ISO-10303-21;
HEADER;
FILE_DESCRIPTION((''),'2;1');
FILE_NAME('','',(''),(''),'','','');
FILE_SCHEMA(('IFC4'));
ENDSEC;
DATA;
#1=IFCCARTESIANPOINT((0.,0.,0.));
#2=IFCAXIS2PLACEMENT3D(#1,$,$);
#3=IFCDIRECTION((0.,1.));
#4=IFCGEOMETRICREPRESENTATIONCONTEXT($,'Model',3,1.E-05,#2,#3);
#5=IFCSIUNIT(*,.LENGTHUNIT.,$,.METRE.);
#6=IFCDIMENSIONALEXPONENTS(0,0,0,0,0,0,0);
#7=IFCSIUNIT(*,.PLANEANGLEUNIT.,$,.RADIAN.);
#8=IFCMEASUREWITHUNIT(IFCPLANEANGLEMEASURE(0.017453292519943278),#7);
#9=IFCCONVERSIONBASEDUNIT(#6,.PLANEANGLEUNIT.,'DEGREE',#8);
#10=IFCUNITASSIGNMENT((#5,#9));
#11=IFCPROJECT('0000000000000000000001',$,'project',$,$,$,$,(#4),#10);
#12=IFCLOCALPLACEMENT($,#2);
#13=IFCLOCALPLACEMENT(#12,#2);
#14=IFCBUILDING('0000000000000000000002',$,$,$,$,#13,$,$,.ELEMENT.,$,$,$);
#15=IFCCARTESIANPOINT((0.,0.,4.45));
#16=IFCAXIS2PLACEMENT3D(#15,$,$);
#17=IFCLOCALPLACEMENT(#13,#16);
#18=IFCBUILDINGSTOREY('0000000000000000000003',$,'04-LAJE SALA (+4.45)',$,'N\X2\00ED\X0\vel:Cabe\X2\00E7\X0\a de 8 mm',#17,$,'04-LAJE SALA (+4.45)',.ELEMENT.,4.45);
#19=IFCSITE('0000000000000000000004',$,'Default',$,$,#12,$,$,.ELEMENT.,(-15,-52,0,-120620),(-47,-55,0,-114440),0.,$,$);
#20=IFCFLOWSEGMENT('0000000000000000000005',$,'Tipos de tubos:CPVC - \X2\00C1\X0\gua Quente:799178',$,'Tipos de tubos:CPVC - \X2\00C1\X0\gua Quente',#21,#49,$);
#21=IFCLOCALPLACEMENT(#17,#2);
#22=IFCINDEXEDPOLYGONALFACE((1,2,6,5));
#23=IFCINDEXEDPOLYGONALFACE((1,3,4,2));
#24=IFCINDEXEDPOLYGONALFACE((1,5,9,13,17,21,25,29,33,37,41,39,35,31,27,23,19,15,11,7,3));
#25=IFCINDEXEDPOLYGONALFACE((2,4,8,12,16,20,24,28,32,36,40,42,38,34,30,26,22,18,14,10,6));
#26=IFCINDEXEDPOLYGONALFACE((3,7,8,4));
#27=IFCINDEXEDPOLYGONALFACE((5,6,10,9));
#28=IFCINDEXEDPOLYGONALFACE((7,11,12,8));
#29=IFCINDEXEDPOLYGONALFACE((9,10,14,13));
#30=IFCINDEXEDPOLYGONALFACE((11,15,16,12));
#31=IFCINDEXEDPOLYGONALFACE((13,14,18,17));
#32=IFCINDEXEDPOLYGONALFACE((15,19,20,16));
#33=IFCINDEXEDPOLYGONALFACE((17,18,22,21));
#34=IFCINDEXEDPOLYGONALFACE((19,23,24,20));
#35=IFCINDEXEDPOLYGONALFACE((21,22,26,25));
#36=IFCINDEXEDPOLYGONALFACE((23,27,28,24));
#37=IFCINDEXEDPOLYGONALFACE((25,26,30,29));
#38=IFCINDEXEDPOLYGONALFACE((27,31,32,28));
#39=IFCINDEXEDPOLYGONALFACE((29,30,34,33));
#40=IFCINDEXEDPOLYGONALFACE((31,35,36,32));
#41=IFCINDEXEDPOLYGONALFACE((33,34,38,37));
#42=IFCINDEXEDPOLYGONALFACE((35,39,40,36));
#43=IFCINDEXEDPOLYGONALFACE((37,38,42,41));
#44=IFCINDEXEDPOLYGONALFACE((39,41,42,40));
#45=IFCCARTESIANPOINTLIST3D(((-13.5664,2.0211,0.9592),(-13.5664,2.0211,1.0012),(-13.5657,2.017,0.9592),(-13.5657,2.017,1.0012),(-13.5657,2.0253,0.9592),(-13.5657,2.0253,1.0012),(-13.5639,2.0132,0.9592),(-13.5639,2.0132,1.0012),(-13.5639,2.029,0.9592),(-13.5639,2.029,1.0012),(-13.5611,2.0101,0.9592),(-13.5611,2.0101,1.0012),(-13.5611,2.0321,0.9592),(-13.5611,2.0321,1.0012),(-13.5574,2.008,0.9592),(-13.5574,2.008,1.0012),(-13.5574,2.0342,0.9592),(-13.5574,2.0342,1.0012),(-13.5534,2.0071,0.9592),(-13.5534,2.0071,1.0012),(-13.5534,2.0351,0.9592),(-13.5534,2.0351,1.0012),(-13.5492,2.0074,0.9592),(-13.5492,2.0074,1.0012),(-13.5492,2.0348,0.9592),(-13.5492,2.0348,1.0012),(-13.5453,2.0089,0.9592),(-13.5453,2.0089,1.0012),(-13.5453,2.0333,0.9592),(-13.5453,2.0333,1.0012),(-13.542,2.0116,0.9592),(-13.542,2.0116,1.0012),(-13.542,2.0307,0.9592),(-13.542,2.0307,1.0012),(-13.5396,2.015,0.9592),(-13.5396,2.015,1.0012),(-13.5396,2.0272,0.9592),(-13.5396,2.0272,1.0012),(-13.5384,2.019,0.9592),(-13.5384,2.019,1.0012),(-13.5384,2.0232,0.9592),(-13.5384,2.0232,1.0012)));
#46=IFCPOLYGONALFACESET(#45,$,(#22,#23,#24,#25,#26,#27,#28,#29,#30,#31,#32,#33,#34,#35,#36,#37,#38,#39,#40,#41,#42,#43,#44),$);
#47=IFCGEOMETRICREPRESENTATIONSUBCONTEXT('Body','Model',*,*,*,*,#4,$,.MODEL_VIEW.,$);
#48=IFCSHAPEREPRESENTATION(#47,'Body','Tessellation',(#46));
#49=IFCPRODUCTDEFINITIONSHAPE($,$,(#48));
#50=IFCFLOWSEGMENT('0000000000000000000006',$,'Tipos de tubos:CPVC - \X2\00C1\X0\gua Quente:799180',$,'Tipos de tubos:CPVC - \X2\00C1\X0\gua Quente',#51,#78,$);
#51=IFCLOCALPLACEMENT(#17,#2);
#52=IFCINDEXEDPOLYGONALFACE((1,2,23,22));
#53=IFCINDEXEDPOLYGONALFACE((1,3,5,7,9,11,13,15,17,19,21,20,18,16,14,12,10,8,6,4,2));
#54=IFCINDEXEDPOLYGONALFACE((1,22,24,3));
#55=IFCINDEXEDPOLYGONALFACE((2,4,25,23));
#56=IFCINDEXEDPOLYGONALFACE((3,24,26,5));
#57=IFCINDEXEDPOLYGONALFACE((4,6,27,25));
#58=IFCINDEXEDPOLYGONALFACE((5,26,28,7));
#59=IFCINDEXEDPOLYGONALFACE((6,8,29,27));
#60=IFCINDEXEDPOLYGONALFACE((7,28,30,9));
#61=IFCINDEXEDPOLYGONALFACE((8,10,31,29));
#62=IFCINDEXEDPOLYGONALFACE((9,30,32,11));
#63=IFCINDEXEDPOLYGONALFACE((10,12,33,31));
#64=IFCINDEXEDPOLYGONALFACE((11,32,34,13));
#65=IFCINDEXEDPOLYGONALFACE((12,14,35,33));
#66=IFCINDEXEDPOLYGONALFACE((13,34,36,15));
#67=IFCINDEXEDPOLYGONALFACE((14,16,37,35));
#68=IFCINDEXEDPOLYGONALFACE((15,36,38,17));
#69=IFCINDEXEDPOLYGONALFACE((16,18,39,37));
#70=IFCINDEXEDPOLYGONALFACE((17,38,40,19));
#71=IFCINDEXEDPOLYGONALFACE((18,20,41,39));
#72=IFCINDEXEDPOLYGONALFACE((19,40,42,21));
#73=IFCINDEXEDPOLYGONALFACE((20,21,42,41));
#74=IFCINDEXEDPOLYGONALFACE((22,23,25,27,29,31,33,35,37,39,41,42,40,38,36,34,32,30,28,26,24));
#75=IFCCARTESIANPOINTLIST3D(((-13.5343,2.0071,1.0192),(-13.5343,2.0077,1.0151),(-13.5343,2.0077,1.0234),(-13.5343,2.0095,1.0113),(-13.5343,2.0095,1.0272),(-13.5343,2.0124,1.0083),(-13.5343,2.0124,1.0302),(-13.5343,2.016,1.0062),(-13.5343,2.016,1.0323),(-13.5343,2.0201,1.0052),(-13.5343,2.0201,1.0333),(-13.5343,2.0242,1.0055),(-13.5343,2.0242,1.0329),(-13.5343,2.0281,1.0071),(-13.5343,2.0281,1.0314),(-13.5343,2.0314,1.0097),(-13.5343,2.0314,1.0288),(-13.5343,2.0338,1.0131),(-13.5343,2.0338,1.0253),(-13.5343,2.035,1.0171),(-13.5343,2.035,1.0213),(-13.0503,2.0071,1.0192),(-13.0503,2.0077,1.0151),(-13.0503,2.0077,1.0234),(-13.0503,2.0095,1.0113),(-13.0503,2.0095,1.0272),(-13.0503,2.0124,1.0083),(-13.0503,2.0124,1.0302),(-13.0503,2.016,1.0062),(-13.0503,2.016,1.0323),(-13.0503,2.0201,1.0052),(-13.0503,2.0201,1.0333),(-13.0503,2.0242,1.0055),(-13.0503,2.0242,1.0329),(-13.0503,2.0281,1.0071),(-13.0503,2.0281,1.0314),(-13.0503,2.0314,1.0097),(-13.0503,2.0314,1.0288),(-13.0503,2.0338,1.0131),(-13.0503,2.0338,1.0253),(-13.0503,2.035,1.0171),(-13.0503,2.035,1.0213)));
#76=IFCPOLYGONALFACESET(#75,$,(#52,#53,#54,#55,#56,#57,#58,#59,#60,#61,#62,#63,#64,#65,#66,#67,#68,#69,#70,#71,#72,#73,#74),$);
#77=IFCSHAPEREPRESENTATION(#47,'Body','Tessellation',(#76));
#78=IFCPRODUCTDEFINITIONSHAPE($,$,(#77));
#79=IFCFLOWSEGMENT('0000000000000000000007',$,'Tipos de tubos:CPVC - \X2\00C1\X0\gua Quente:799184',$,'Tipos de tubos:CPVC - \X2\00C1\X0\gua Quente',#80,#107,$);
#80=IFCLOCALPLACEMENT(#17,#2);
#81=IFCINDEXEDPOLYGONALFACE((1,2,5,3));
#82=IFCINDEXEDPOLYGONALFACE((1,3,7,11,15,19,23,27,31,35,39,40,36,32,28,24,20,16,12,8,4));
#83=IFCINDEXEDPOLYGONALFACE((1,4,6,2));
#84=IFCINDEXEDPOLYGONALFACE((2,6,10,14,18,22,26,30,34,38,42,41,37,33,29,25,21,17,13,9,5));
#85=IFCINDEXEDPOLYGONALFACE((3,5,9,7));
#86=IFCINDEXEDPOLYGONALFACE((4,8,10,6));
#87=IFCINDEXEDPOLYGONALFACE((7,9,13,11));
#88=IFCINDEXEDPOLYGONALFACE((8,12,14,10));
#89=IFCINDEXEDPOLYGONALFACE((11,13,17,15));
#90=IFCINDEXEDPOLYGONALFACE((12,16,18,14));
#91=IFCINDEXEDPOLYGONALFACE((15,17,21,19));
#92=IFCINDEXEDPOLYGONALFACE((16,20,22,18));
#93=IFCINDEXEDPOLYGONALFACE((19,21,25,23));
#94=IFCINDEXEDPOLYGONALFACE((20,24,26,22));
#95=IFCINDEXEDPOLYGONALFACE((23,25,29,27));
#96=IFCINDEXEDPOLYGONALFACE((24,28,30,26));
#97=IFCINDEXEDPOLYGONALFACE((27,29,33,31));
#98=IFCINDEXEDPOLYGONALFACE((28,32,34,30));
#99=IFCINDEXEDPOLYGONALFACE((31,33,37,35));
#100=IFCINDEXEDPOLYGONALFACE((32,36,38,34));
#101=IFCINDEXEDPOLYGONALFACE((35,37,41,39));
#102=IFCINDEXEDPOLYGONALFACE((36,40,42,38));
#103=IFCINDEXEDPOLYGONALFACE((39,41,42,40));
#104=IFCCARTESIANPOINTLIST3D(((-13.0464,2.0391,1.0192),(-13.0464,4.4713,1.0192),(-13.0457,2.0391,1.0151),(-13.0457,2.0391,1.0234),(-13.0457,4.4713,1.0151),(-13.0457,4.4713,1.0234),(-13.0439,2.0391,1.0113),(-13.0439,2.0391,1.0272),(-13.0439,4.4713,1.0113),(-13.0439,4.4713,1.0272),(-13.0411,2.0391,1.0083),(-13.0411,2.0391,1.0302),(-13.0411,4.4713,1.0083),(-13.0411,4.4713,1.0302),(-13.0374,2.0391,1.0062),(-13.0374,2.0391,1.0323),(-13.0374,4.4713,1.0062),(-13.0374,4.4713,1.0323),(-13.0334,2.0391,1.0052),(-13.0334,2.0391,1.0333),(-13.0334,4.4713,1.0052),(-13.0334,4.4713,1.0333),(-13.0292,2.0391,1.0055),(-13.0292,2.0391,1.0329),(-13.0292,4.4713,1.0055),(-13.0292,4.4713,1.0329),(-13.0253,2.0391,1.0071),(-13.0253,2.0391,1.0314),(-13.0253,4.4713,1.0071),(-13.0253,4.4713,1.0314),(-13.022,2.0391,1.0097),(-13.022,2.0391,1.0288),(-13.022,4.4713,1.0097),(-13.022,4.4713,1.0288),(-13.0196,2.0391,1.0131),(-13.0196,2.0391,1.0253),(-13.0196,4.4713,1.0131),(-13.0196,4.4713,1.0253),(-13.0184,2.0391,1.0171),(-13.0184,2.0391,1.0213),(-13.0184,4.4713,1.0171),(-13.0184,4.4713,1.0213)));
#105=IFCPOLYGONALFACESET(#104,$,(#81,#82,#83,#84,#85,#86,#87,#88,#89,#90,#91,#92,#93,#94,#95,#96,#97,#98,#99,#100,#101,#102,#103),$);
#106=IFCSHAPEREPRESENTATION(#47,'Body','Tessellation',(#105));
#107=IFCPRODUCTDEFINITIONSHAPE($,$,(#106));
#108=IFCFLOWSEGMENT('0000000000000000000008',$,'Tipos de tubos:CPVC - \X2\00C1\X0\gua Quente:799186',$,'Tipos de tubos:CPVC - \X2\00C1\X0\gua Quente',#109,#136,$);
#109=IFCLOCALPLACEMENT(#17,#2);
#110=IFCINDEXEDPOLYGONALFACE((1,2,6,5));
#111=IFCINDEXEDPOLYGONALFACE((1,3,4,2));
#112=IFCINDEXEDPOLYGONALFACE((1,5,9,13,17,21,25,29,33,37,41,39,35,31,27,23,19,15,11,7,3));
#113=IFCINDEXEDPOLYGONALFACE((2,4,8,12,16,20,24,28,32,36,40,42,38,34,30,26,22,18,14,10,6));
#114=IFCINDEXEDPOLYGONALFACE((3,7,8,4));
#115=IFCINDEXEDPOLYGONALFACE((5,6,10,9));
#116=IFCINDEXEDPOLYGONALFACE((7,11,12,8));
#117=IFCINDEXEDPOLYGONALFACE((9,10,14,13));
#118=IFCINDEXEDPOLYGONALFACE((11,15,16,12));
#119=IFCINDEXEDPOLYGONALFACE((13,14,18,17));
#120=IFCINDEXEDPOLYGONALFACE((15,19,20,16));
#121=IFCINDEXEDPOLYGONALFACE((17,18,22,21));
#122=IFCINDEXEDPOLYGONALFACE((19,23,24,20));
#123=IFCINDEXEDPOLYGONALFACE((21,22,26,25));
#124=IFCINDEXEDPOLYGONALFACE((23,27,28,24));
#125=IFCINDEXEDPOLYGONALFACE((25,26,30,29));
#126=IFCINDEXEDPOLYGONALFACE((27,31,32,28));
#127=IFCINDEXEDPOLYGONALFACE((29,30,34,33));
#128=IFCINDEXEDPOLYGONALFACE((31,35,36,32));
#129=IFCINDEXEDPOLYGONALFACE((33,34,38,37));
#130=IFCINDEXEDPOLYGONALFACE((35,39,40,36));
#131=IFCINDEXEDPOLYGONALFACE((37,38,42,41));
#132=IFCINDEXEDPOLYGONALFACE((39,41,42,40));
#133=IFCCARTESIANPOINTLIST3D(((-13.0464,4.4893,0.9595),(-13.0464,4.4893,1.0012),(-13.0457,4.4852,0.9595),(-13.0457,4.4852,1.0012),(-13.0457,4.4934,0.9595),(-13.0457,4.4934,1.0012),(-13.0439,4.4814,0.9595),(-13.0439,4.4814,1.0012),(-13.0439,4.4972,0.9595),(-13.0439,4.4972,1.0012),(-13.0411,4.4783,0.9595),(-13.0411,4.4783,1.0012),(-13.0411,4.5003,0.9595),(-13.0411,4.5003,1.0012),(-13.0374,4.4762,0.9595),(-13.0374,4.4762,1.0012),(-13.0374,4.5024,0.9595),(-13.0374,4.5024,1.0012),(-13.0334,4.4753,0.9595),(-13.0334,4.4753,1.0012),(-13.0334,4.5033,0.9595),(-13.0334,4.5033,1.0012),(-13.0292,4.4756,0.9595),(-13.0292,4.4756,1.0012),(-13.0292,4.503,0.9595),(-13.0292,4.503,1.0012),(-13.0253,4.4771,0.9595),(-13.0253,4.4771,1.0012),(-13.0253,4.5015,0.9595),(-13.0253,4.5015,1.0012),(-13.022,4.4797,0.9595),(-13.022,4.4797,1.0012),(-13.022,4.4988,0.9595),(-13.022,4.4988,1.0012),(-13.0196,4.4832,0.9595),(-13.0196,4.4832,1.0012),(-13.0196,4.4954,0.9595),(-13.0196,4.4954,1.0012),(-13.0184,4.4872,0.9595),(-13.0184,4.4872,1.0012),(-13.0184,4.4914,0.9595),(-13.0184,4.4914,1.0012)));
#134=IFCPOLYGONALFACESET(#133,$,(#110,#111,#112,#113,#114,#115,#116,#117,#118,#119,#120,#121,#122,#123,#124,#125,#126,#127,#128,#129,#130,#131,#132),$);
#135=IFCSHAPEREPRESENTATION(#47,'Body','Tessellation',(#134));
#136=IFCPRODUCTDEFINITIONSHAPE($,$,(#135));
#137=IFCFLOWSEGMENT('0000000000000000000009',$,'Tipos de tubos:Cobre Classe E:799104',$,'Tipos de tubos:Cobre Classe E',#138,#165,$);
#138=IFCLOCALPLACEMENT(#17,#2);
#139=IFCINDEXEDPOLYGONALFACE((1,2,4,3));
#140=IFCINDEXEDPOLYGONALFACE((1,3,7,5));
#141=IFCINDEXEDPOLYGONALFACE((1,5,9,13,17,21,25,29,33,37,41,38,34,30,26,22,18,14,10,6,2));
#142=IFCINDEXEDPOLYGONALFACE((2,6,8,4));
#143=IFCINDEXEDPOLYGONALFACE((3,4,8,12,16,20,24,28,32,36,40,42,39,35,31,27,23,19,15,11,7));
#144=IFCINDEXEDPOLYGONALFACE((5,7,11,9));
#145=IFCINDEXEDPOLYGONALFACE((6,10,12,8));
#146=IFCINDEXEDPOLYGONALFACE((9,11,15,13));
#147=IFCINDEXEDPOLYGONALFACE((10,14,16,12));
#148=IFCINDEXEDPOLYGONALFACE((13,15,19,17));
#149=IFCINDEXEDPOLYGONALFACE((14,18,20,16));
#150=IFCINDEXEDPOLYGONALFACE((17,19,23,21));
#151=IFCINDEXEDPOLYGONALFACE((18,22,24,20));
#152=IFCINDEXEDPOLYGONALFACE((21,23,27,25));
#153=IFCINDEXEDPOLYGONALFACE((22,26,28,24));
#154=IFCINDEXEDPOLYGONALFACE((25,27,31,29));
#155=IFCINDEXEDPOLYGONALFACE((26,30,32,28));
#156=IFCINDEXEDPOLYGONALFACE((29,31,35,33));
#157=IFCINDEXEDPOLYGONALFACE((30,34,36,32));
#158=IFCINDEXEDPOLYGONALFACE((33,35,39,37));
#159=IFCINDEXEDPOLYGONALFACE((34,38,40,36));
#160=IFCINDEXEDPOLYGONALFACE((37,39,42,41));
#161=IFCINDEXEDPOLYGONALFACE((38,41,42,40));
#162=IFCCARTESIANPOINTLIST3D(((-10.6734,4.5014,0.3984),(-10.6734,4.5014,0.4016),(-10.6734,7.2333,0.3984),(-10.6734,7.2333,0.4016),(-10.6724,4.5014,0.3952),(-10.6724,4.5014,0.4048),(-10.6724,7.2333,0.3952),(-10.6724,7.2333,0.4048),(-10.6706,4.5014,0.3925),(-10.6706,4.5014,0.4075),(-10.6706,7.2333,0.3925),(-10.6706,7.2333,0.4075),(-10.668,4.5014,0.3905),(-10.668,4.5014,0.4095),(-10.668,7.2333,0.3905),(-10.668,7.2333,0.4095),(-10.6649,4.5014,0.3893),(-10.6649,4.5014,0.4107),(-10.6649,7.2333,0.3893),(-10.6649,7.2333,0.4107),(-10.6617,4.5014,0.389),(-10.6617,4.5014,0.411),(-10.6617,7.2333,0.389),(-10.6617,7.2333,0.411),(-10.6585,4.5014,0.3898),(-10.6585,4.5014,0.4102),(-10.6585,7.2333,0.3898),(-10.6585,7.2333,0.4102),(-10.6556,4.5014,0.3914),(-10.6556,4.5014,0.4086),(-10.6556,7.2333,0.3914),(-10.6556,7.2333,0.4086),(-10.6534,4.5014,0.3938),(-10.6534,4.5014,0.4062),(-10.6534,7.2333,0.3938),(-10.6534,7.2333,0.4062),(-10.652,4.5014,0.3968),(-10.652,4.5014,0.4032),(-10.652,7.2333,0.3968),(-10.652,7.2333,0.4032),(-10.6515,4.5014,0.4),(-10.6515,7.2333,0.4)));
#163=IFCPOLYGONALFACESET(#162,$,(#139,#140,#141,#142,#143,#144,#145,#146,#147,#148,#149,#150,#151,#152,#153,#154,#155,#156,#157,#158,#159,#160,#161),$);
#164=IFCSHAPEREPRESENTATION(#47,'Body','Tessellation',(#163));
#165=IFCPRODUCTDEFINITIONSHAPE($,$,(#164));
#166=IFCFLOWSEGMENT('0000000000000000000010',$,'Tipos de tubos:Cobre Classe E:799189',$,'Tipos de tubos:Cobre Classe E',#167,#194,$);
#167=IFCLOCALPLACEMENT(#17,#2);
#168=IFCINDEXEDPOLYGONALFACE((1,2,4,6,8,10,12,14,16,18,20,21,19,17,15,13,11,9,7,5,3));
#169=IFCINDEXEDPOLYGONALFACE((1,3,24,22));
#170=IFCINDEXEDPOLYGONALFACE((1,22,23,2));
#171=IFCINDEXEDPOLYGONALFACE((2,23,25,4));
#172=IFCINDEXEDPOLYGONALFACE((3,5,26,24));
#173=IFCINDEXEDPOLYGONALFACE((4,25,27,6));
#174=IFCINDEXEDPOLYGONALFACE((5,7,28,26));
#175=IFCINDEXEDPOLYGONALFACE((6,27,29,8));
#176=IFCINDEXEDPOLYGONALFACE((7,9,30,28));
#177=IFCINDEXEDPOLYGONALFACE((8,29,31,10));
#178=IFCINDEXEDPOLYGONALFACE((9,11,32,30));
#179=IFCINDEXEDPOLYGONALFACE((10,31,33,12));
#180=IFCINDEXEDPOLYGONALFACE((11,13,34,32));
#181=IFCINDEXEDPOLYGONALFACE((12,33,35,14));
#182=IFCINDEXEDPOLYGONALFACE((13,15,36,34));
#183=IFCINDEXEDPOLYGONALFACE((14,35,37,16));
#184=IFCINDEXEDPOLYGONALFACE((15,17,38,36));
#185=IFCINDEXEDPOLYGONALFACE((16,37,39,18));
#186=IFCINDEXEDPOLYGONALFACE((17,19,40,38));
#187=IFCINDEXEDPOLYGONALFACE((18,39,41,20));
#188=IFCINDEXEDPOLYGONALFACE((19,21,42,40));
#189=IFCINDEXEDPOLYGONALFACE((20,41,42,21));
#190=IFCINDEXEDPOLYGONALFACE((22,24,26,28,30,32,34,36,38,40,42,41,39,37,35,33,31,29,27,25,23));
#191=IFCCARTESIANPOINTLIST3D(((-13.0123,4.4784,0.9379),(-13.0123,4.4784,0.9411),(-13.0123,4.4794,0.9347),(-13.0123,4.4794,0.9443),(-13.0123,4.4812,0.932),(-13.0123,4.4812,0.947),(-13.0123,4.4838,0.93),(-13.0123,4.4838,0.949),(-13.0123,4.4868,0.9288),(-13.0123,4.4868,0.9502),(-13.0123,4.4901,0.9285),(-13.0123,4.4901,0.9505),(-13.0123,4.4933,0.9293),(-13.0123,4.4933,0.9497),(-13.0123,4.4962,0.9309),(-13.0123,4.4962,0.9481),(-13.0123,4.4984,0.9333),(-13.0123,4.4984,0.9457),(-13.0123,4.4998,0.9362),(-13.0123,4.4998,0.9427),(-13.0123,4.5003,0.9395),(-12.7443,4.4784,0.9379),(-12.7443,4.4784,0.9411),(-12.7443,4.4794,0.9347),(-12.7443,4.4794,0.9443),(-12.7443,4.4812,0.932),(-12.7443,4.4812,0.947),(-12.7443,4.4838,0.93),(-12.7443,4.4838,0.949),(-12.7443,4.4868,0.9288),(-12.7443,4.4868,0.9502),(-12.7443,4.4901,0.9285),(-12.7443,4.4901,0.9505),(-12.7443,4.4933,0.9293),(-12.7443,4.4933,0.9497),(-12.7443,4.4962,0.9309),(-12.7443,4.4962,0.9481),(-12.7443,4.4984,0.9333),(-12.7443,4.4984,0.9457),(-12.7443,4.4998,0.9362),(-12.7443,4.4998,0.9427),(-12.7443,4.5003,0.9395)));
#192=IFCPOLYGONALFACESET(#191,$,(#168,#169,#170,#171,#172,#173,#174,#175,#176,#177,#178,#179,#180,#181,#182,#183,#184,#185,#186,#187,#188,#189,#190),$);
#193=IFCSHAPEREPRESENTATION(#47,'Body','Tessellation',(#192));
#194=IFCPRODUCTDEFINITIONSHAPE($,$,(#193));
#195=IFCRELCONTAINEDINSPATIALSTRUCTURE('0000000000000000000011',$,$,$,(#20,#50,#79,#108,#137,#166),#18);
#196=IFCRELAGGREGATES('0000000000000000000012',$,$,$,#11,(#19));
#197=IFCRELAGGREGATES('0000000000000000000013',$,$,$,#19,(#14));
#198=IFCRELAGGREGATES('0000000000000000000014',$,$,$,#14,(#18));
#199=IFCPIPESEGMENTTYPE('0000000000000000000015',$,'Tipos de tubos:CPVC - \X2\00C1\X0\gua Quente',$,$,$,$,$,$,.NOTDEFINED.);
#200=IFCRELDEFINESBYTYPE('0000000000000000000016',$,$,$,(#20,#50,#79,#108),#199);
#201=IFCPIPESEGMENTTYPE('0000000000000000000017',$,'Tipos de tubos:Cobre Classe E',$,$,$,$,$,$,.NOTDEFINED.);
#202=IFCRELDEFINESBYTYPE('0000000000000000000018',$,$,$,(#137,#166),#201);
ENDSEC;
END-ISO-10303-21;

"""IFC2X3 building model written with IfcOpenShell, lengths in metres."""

from ifc_helpers import new_model, entity, si_unit, converted_unit, direction, frame, frame_2d, origin, origin_2d_with_axis, place, context, subcontext, project, spatial, circle, extrude, type_object, element, save


model = new_model("IFC2X3")

# Units and contexts
model_context = context("Model", 3, precision=1e-05, world=origin(), true_north=direction((0.0, 1.0)))
body_context = subcontext(model_context, "Body", "Model", "MODEL_VIEW")
ifc_project = project(units=[si_unit("LENGTHUNIT", "METRE"), converted_unit("PLANEANGLEUNIT", "DEGREE", entity("IfcPlaneAngleMeasure", 0.017453292519943278), si_unit("PLANEANGLEUNIT", "RADIAN"), dimensions=[0, 0, 0, 0, 0, 0, 0])], contexts=[model_context])

# Site, building, storey
site_placement = place(None, origin())
site = spatial("IfcSite", under=ifc_project, at=site_placement, Name="Default", CompositionType="ELEMENT", RefLatitude=(-15, -52, 0, -120620), RefLongitude=(-47, -55, 0, -114440), RefElevation=0.0)
building_placement = place(site_placement, origin())
building = spatial("IfcBuilding", under=site, at=building_placement, CompositionType="ELEMENT")
storey_placement = place(building_placement, frame((0.0, 0.0, 4.45)))
storey = spatial("IfcBuildingStorey", under=building, at=storey_placement, Name="04-LAJE SALA (+4.45)", ObjectType="Nível:Cabeça de 8 mm", LongName="04-LAJE SALA (+4.45)", CompositionType="ELEMENT", Elevation=4.45)

# Flow segments
pipe_segment_type_1 = type_object("IfcPipeSegmentType", Name="Tipos de tubos:CPVC - Água Quente", PredefinedType="NOTDEFINED")
flow_segment_1_placement = place(storey_placement, origin())
element("IfcFlowSegment", 1, at=flow_segment_1_placement, inside=storey, type_object=pipe_segment_type_1, Name="Tipos de tubos:CPVC - Água Quente:799178", ObjectType="Tipos de tubos:CPVC - Água Quente", context=body_context, shape_type="SweptSolid", body=[
    extrude(circle(Radius=0.0141, at=origin_2d_with_axis()), frame((-13.5523, 2.0211, 0.9592), z_axis=(0.0, 0.0, 1.0), x_axis=(-1.0, 0.0, 0.0)), (0.0, 0.0, 1.0), 0.042),
])
flow_segment_2_placement = place(storey_placement, origin())
element("IfcFlowSegment", 2, at=flow_segment_2_placement, inside=storey, type_object=pipe_segment_type_1, Name="Tipos de tubos:CPVC - Água Quente:799180", ObjectType="Tipos de tubos:CPVC - Água Quente", context=body_context, shape_type="SweptSolid", body=[
    extrude(circle(Radius=0.0141, at=origin_2d_with_axis()), frame((-13.5343, 2.0211, 1.0192), z_axis=(1.0, 0.0, 0.0), x_axis=(0.0, -1.0, 0.0)), (0.0, 0.0, 1.0), 0.484),
])
flow_segment_3_placement = place(storey_placement, origin())
element("IfcFlowSegment", 3, at=flow_segment_3_placement, inside=storey, type_object=pipe_segment_type_1, Name="Tipos de tubos:CPVC - Água Quente:799184", ObjectType="Tipos de tubos:CPVC - Água Quente", context=body_context, shape_type="SweptSolid", body=[
    extrude(circle(Radius=0.0141, at=origin_2d_with_axis()), frame((-13.0323, 2.0391, 1.0192), z_axis=(0.0, 1.0, 0.0), x_axis=(-1.0, 0.0, 0.0)), (0.0, 0.0, 1.0), 2.4322),
])
flow_segment_4_placement = place(storey_placement, origin())
element("IfcFlowSegment", 4, at=flow_segment_4_placement, inside=storey, type_object=pipe_segment_type_1, Name="Tipos de tubos:CPVC - Água Quente:799186", ObjectType="Tipos de tubos:CPVC - Água Quente", context=body_context, shape_type="SweptSolid", body=[
    extrude(circle(Radius=0.0141, at=origin_2d_with_axis()), frame((-13.0323, 4.4893, 0.9595), z_axis=(0.0, 0.0, 1.0), x_axis=(-1.0, 0.0, 0.0)), (0.0, 0.0, 1.0), 0.0418),
])
pipe_segment_type_2 = type_object("IfcPipeSegmentType", Name="Tipos de tubos:Cobre Classe E", PredefinedType="NOTDEFINED")
flow_segment_5_placement = place(storey_placement, origin())
element("IfcFlowSegment", 5, at=flow_segment_5_placement, inside=storey, type_object=pipe_segment_type_2, Name="Tipos de tubos:Cobre Classe E:799104", ObjectType="Tipos de tubos:Cobre Classe E", context=body_context, shape_type="SweptSolid", body=[
    extrude(circle(Radius=0.011, at=frame_2d((0.0, 0.0), x_axis=(1.0, 0.0))), frame((-10.6625, 4.5014, 0.4), z_axis=(0.0, 1.0, 0.0), x_axis=(1.0, 0.0, 0.0)), (0.0, 0.0, 1.0), 2.7319),
])
flow_segment_6_placement = place(storey_placement, origin())
element("IfcFlowSegment", 6, at=flow_segment_6_placement, inside=storey, type_object=pipe_segment_type_2, Name="Tipos de tubos:Cobre Classe E:799189", ObjectType="Tipos de tubos:Cobre Classe E", context=body_context, shape_type="SweptSolid", body=[
    extrude(circle(Radius=0.011, at=origin_2d_with_axis()), frame((-13.0123, 4.4893, 0.9395), z_axis=(1.0, 0.0, 0.0), x_axis=(0.0, 1.0, 0.0)), (0.0, 0.0, 1.0), 0.268),
])

save(model, "model.ifc")
